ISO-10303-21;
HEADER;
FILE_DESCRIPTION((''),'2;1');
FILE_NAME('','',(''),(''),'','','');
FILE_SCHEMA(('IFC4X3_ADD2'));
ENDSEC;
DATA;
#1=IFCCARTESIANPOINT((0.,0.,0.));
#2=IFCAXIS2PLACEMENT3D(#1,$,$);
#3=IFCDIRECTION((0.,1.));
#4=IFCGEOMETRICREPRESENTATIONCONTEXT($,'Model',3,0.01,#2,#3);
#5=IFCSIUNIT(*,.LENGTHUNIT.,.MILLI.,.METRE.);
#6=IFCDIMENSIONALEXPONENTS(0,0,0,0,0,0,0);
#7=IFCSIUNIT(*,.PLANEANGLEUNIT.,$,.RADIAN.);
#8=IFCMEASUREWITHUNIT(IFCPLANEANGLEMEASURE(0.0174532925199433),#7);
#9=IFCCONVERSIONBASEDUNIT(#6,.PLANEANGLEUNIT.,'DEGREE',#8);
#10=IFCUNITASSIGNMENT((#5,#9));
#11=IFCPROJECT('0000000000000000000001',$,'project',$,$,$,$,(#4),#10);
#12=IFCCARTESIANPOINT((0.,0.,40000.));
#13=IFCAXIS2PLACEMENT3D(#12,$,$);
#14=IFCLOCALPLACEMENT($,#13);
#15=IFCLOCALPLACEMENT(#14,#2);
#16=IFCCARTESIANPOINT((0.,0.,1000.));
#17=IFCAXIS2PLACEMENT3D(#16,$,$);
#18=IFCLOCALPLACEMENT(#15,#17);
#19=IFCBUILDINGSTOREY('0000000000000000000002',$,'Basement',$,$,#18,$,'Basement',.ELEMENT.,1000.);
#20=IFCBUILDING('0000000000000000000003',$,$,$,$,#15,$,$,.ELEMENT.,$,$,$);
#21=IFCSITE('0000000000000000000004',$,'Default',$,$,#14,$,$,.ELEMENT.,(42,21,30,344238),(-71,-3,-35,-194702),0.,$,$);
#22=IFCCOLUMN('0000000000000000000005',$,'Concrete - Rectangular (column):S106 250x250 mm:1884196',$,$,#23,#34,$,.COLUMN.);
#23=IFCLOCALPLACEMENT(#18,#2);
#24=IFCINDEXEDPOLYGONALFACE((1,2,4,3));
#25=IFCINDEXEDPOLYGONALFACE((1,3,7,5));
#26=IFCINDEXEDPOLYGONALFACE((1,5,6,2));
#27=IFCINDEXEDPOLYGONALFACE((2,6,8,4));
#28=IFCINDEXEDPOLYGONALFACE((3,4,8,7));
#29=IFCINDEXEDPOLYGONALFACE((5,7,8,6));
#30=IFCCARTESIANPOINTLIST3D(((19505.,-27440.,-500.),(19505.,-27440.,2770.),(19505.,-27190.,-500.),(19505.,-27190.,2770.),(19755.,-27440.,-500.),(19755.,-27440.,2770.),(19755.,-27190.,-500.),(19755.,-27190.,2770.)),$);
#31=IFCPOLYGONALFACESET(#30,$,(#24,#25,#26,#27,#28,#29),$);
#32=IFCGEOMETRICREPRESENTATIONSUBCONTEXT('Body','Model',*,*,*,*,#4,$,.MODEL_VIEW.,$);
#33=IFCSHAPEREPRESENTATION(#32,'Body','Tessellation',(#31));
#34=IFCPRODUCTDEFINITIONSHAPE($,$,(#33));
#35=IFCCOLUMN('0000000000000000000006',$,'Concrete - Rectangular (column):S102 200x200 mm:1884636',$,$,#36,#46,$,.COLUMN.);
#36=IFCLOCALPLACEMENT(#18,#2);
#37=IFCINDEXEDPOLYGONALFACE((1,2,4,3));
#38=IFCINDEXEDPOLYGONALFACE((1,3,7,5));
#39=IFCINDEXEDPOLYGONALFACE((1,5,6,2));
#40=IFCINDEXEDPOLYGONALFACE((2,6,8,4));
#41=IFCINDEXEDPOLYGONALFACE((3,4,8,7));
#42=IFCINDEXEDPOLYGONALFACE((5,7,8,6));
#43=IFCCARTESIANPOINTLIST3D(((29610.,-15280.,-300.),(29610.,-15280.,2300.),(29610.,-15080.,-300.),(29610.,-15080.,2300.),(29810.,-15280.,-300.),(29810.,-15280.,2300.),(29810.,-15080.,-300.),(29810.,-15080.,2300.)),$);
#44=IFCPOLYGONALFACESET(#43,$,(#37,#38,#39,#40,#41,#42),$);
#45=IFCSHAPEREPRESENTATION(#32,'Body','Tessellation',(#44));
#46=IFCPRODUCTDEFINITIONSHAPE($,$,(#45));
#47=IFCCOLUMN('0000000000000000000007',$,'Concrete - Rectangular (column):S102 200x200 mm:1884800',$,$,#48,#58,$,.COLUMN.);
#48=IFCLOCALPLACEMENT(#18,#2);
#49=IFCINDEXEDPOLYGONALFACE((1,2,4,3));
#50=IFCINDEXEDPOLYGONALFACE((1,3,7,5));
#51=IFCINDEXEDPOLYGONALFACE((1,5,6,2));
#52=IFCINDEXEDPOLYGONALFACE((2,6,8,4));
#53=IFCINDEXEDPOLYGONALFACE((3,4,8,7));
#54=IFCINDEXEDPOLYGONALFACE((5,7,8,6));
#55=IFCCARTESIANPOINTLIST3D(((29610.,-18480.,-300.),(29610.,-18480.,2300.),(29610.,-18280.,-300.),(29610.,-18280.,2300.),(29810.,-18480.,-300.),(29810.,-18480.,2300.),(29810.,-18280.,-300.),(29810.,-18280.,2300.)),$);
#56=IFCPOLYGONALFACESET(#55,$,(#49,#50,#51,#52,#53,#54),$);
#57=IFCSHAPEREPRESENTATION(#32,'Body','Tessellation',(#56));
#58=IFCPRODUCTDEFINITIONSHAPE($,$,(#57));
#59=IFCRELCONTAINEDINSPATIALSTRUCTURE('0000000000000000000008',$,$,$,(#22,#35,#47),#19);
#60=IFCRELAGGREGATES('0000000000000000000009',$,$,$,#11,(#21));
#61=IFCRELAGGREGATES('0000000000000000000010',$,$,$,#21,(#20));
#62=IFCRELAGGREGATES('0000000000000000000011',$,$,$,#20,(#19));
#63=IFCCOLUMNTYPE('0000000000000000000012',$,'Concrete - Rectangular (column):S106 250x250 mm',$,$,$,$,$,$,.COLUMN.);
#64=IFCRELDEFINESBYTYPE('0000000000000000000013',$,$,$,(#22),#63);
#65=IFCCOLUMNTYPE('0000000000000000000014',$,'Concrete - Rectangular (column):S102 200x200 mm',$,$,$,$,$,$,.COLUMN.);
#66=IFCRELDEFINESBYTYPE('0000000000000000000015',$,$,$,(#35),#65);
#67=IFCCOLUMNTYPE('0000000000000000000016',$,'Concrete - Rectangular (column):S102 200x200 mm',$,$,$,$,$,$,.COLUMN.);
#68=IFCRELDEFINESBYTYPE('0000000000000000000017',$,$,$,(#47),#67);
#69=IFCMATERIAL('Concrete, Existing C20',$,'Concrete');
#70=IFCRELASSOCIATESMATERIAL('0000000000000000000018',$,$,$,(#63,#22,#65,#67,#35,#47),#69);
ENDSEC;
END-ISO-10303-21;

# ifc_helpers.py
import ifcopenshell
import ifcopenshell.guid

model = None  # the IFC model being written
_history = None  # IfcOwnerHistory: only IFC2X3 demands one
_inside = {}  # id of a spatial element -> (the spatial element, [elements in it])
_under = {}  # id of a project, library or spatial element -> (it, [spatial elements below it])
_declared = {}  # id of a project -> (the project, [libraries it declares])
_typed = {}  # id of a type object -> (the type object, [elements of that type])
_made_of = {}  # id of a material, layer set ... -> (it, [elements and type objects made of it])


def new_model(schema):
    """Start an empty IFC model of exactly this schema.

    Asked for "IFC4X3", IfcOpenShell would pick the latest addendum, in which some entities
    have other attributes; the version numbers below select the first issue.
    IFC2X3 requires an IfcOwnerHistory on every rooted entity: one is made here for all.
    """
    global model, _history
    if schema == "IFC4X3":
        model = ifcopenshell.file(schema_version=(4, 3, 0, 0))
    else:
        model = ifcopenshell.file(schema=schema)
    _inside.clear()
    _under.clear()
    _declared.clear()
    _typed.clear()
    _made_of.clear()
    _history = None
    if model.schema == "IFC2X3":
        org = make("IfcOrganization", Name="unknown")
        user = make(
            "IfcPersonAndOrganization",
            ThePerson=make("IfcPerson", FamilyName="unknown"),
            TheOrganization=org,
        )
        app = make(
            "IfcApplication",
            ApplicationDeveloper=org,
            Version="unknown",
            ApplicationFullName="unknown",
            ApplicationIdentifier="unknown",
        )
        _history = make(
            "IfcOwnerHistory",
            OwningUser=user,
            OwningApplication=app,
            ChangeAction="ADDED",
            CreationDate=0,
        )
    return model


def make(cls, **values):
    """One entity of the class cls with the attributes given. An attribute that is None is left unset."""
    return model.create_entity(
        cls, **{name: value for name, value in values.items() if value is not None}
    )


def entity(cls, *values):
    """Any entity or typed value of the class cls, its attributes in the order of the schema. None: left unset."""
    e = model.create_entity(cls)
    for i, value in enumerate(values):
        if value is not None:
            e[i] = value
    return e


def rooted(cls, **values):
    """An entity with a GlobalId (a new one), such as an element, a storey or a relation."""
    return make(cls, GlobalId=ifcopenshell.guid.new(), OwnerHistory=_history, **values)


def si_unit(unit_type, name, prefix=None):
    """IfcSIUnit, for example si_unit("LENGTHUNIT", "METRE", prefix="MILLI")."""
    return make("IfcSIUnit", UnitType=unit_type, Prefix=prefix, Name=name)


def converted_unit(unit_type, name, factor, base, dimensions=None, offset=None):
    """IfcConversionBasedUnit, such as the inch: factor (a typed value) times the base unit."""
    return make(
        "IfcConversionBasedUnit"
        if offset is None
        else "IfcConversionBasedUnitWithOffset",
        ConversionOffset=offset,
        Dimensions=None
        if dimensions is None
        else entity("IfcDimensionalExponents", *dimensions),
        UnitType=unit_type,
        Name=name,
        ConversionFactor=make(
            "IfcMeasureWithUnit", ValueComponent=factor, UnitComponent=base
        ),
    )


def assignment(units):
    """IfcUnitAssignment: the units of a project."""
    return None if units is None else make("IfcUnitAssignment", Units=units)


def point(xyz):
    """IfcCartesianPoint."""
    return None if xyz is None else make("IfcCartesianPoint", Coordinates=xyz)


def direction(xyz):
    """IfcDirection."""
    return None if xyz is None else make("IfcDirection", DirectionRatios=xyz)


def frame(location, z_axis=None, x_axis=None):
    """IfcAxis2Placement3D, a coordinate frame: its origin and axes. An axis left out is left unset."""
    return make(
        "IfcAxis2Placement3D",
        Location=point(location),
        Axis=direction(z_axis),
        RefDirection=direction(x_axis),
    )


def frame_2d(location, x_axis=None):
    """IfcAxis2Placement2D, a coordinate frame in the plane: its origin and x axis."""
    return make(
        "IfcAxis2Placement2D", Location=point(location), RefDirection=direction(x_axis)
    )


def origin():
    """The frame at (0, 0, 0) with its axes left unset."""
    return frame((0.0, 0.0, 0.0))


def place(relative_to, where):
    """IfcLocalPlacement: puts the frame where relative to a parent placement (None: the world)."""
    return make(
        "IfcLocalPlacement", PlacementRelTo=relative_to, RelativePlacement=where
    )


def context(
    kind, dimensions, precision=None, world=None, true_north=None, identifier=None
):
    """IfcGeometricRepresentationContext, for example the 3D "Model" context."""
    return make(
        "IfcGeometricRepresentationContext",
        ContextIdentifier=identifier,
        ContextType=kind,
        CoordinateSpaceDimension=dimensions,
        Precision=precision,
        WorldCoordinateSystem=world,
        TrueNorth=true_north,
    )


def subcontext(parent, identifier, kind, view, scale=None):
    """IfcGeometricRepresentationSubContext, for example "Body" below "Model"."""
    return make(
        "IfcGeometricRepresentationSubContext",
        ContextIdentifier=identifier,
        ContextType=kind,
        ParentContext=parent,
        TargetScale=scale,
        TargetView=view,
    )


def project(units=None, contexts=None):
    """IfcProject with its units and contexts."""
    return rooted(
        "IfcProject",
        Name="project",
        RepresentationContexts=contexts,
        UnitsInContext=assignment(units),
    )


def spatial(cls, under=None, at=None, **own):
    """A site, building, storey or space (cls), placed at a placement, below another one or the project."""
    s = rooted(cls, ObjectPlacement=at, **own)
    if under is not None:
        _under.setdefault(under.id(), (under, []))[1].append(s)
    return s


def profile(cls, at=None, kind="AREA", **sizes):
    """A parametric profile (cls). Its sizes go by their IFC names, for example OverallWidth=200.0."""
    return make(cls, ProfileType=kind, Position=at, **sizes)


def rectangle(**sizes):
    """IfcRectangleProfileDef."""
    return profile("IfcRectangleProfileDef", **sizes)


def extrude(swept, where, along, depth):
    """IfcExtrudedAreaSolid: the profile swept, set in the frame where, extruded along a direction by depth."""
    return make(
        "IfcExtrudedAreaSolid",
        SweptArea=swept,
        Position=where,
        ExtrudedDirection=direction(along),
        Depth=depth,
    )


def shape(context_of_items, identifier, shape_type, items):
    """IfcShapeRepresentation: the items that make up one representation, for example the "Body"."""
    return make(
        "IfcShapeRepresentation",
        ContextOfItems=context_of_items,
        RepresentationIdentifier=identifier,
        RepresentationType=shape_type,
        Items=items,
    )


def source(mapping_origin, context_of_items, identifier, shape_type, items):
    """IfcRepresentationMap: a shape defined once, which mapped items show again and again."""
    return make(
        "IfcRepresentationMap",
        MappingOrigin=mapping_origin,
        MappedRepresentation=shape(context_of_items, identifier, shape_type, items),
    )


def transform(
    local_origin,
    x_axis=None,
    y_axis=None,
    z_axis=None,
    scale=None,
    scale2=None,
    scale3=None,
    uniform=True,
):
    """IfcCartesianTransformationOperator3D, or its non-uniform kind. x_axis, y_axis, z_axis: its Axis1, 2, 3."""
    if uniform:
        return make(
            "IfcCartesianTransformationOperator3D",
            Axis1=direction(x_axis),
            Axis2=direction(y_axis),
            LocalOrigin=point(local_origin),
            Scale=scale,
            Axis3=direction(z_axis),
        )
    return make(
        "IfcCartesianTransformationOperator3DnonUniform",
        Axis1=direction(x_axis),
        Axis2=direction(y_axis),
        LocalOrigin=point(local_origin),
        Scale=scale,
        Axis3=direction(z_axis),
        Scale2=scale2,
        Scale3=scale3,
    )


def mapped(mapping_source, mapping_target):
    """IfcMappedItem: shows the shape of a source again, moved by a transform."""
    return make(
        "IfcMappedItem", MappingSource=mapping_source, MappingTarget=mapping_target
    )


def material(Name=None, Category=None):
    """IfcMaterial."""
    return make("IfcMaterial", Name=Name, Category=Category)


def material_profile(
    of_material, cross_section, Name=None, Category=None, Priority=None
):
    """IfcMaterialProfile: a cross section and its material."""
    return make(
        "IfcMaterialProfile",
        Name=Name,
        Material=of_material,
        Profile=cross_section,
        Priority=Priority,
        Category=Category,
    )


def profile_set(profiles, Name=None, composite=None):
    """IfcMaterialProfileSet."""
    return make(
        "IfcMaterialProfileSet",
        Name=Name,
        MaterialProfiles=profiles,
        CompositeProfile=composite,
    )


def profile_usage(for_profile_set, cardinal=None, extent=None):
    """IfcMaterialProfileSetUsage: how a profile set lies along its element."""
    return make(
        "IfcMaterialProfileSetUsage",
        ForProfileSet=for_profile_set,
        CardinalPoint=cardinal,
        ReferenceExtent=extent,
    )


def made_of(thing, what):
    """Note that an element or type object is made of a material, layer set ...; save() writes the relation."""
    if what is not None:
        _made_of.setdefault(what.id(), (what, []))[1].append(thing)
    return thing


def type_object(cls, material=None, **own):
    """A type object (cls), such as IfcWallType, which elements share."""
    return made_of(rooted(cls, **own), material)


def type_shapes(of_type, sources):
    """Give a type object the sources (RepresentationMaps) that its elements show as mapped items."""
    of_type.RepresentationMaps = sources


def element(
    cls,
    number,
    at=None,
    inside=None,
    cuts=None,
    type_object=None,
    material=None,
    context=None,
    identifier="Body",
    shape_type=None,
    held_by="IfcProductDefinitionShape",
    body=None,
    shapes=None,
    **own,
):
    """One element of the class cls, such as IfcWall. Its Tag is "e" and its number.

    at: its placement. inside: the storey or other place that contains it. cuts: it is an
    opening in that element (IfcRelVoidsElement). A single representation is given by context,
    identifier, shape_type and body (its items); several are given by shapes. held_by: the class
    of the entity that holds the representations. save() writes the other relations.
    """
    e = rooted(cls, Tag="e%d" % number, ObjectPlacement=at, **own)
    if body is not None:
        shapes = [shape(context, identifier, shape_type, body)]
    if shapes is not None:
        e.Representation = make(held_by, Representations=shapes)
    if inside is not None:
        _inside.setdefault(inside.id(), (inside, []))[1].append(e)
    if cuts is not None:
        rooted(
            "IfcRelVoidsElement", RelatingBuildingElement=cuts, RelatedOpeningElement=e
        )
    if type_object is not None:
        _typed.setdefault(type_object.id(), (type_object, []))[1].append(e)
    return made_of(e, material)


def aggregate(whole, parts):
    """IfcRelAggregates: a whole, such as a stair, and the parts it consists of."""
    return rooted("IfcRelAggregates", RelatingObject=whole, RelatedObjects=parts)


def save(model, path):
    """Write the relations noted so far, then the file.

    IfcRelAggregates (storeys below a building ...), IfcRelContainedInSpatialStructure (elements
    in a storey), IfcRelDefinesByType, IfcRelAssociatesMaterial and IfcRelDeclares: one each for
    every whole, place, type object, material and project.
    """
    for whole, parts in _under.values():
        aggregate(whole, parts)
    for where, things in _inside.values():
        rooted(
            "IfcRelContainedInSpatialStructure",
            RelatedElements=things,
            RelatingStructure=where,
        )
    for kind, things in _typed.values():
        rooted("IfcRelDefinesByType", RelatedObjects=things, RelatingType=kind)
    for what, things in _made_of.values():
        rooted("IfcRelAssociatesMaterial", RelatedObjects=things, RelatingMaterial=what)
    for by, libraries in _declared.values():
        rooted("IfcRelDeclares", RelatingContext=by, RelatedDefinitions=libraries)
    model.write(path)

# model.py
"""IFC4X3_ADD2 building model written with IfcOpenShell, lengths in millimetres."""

from ifc_helpers import new_model, entity, si_unit, converted_unit, direction, frame, frame_2d, origin, place, context, subcontext, project, spatial, rectangle, extrude, source, transform, mapped, material, material_profile, profile_set, profile_usage, type_object, type_shapes, element, save


model = new_model("IFC4X3_ADD2")

# Units and contexts
model_context = context("Model", 3, precision=0.01, world=origin(), true_north=direction((0.0, 1.0)))
body_context = subcontext(model_context, "Body", "Model", "MODEL_VIEW")
ifc_project = project(units=[si_unit("LENGTHUNIT", "METRE", prefix="MILLI"), converted_unit("PLANEANGLEUNIT", "DEGREE", entity("IfcPlaneAngleMeasure", 0.0174532925199433), si_unit("PLANEANGLEUNIT", "RADIAN"), dimensions=[0, 0, 0, 0, 0, 0, 0])], contexts=[model_context])

# Site, building, storey
site_placement = place(None, frame((0.0, 0.0, 40000.0)))
site = spatial("IfcSite", under=ifc_project, at=site_placement, Name="Default", CompositionType="ELEMENT", RefLatitude=(42, 21, 30, 344238), RefLongitude=(-71, -3, -35, -194702), RefElevation=0.0)
building_placement = place(site_placement, origin())
building = spatial("IfcBuilding", under=site, at=building_placement, CompositionType="ELEMENT")
storey_placement = place(building_placement, frame((0.0, 0.0, 1000.0)))
storey = spatial("IfcBuildingStorey", under=building, at=storey_placement, Name="Basement", LongName="Basement", CompositionType="ELEMENT", Elevation=1000.0)

# Columns
ifc_material = material(Name="Concrete, Existing C20", Category="Concrete")
ifc_material_profile_1 = material_profile(ifc_material, rectangle(XDim=200.0, YDim=200.0, at=frame_2d((0.0, 0.0), x_axis=(1.0, 0.0))), Name="S102 200x200 mm")
ifc_profile_set_1 = profile_set([ifc_material_profile_1], Name="S102 200x200 mm")
ifc_profile_usage_1 = profile_usage(ifc_profile_set_1)
ifc_material_profile_2 = material_profile(ifc_material, rectangle(XDim=250.0, YDim=250.0, at=frame_2d((0.0, 0.0), x_axis=(1.0, 0.0))), Name="S106 250x250 mm")
ifc_profile_set_2 = profile_set([ifc_material_profile_2], Name="S106 250x250 mm")
ifc_profile_usage_2 = profile_usage(ifc_profile_set_2)
column_type_1 = type_object("IfcColumnType", Name="Concrete - Rectangular (column):S106 250x250 mm", PredefinedType="COLUMN", material=ifc_profile_set_2)
shared_shape_1 = source(origin(), body_context, "Body", "SweptSolid", [
    extrude(rectangle(XDim=250.0, YDim=250.0, at=frame_2d((0.0, 0.0), x_axis=(1.0, 0.0))), frame((19630.0, -27315.0, 500.0), z_axis=(0.0, 0.0, 1.0), x_axis=(0.0, 1.0, 0.0)), (0.0, 0.0, 1.0), 3270.0),
])
type_shapes(column_type_1, [shared_shape_1])
column_1_placement = place(storey_placement, frame((0.0, 0.0, -1000.0)))
element("IfcColumn", 1, at=column_1_placement, inside=storey, type_object=column_type_1, material=ifc_profile_usage_2, Name="Concrete - Rectangular (column):S106 250x250 mm:1884196", PredefinedType="COLUMN", context=body_context, shape_type="MappedRepresentation", body=[
    mapped(shared_shape_1, transform((0.0, 0.0, 0.0), scale=1.0)),
])
column_type_2 = type_object("IfcColumnType", Name="Concrete - Rectangular (column):S102 200x200 mm", PredefinedType="COLUMN", material=ifc_profile_set_1)
shared_shape_2 = source(origin(), body_context, "Body", "SweptSolid", [
    extrude(rectangle(XDim=200.0, YDim=200.0, at=frame_2d((0.0, 0.0), x_axis=(1.0, 0.0))), frame((29710.0, -15180.0, 700.0), z_axis=(0.0, 0.0, 1.0), x_axis=(0.0, 1.0, 0.0)), (0.0, 0.0, 1.0), 2600.0),
])
type_shapes(column_type_2, [shared_shape_2])
column_2_placement = place(storey_placement, frame((0.0, 0.0, -1000.0)))
element("IfcColumn", 2, at=column_2_placement, inside=storey, type_object=column_type_2, material=ifc_profile_usage_1, Name="Concrete - Rectangular (column):S102 200x200 mm:1884636", PredefinedType="COLUMN", context=body_context, shape_type="MappedRepresentation", body=[
    mapped(shared_shape_2, transform((0.0, 0.0, 0.0), scale=1.0)),
])
column_type_3 = type_object("IfcColumnType", Name="Concrete - Rectangular (column):S102 200x200 mm", PredefinedType="COLUMN", material=ifc_profile_set_1)
shared_shape_3 = source(origin(), body_context, "Body", "SweptSolid", [
    extrude(rectangle(XDim=200.0, YDim=200.0, at=frame_2d((0.0, 0.0), x_axis=(1.0, 0.0))), frame((29710.0, -18380.0, 700.0), z_axis=(0.0, 0.0, 1.0), x_axis=(0.0, 1.0, 0.0)), (0.0, 0.0, 1.0), 2600.0),
])
type_shapes(column_type_3, [shared_shape_3])
column_3_placement = place(storey_placement, frame((0.0, 0.0, -1000.0)))
element("IfcColumn", 3, at=column_3_placement, inside=storey, type_object=column_type_3, material=ifc_profile_usage_1, Name="Concrete - Rectangular (column):S102 200x200 mm:1884800", PredefinedType="COLUMN", context=body_context, shape_type="MappedRepresentation", body=[
    mapped(shared_shape_3, transform((0.0, 0.0, 0.0), scale=1.0)),
])

save(model, "model.ifc")
